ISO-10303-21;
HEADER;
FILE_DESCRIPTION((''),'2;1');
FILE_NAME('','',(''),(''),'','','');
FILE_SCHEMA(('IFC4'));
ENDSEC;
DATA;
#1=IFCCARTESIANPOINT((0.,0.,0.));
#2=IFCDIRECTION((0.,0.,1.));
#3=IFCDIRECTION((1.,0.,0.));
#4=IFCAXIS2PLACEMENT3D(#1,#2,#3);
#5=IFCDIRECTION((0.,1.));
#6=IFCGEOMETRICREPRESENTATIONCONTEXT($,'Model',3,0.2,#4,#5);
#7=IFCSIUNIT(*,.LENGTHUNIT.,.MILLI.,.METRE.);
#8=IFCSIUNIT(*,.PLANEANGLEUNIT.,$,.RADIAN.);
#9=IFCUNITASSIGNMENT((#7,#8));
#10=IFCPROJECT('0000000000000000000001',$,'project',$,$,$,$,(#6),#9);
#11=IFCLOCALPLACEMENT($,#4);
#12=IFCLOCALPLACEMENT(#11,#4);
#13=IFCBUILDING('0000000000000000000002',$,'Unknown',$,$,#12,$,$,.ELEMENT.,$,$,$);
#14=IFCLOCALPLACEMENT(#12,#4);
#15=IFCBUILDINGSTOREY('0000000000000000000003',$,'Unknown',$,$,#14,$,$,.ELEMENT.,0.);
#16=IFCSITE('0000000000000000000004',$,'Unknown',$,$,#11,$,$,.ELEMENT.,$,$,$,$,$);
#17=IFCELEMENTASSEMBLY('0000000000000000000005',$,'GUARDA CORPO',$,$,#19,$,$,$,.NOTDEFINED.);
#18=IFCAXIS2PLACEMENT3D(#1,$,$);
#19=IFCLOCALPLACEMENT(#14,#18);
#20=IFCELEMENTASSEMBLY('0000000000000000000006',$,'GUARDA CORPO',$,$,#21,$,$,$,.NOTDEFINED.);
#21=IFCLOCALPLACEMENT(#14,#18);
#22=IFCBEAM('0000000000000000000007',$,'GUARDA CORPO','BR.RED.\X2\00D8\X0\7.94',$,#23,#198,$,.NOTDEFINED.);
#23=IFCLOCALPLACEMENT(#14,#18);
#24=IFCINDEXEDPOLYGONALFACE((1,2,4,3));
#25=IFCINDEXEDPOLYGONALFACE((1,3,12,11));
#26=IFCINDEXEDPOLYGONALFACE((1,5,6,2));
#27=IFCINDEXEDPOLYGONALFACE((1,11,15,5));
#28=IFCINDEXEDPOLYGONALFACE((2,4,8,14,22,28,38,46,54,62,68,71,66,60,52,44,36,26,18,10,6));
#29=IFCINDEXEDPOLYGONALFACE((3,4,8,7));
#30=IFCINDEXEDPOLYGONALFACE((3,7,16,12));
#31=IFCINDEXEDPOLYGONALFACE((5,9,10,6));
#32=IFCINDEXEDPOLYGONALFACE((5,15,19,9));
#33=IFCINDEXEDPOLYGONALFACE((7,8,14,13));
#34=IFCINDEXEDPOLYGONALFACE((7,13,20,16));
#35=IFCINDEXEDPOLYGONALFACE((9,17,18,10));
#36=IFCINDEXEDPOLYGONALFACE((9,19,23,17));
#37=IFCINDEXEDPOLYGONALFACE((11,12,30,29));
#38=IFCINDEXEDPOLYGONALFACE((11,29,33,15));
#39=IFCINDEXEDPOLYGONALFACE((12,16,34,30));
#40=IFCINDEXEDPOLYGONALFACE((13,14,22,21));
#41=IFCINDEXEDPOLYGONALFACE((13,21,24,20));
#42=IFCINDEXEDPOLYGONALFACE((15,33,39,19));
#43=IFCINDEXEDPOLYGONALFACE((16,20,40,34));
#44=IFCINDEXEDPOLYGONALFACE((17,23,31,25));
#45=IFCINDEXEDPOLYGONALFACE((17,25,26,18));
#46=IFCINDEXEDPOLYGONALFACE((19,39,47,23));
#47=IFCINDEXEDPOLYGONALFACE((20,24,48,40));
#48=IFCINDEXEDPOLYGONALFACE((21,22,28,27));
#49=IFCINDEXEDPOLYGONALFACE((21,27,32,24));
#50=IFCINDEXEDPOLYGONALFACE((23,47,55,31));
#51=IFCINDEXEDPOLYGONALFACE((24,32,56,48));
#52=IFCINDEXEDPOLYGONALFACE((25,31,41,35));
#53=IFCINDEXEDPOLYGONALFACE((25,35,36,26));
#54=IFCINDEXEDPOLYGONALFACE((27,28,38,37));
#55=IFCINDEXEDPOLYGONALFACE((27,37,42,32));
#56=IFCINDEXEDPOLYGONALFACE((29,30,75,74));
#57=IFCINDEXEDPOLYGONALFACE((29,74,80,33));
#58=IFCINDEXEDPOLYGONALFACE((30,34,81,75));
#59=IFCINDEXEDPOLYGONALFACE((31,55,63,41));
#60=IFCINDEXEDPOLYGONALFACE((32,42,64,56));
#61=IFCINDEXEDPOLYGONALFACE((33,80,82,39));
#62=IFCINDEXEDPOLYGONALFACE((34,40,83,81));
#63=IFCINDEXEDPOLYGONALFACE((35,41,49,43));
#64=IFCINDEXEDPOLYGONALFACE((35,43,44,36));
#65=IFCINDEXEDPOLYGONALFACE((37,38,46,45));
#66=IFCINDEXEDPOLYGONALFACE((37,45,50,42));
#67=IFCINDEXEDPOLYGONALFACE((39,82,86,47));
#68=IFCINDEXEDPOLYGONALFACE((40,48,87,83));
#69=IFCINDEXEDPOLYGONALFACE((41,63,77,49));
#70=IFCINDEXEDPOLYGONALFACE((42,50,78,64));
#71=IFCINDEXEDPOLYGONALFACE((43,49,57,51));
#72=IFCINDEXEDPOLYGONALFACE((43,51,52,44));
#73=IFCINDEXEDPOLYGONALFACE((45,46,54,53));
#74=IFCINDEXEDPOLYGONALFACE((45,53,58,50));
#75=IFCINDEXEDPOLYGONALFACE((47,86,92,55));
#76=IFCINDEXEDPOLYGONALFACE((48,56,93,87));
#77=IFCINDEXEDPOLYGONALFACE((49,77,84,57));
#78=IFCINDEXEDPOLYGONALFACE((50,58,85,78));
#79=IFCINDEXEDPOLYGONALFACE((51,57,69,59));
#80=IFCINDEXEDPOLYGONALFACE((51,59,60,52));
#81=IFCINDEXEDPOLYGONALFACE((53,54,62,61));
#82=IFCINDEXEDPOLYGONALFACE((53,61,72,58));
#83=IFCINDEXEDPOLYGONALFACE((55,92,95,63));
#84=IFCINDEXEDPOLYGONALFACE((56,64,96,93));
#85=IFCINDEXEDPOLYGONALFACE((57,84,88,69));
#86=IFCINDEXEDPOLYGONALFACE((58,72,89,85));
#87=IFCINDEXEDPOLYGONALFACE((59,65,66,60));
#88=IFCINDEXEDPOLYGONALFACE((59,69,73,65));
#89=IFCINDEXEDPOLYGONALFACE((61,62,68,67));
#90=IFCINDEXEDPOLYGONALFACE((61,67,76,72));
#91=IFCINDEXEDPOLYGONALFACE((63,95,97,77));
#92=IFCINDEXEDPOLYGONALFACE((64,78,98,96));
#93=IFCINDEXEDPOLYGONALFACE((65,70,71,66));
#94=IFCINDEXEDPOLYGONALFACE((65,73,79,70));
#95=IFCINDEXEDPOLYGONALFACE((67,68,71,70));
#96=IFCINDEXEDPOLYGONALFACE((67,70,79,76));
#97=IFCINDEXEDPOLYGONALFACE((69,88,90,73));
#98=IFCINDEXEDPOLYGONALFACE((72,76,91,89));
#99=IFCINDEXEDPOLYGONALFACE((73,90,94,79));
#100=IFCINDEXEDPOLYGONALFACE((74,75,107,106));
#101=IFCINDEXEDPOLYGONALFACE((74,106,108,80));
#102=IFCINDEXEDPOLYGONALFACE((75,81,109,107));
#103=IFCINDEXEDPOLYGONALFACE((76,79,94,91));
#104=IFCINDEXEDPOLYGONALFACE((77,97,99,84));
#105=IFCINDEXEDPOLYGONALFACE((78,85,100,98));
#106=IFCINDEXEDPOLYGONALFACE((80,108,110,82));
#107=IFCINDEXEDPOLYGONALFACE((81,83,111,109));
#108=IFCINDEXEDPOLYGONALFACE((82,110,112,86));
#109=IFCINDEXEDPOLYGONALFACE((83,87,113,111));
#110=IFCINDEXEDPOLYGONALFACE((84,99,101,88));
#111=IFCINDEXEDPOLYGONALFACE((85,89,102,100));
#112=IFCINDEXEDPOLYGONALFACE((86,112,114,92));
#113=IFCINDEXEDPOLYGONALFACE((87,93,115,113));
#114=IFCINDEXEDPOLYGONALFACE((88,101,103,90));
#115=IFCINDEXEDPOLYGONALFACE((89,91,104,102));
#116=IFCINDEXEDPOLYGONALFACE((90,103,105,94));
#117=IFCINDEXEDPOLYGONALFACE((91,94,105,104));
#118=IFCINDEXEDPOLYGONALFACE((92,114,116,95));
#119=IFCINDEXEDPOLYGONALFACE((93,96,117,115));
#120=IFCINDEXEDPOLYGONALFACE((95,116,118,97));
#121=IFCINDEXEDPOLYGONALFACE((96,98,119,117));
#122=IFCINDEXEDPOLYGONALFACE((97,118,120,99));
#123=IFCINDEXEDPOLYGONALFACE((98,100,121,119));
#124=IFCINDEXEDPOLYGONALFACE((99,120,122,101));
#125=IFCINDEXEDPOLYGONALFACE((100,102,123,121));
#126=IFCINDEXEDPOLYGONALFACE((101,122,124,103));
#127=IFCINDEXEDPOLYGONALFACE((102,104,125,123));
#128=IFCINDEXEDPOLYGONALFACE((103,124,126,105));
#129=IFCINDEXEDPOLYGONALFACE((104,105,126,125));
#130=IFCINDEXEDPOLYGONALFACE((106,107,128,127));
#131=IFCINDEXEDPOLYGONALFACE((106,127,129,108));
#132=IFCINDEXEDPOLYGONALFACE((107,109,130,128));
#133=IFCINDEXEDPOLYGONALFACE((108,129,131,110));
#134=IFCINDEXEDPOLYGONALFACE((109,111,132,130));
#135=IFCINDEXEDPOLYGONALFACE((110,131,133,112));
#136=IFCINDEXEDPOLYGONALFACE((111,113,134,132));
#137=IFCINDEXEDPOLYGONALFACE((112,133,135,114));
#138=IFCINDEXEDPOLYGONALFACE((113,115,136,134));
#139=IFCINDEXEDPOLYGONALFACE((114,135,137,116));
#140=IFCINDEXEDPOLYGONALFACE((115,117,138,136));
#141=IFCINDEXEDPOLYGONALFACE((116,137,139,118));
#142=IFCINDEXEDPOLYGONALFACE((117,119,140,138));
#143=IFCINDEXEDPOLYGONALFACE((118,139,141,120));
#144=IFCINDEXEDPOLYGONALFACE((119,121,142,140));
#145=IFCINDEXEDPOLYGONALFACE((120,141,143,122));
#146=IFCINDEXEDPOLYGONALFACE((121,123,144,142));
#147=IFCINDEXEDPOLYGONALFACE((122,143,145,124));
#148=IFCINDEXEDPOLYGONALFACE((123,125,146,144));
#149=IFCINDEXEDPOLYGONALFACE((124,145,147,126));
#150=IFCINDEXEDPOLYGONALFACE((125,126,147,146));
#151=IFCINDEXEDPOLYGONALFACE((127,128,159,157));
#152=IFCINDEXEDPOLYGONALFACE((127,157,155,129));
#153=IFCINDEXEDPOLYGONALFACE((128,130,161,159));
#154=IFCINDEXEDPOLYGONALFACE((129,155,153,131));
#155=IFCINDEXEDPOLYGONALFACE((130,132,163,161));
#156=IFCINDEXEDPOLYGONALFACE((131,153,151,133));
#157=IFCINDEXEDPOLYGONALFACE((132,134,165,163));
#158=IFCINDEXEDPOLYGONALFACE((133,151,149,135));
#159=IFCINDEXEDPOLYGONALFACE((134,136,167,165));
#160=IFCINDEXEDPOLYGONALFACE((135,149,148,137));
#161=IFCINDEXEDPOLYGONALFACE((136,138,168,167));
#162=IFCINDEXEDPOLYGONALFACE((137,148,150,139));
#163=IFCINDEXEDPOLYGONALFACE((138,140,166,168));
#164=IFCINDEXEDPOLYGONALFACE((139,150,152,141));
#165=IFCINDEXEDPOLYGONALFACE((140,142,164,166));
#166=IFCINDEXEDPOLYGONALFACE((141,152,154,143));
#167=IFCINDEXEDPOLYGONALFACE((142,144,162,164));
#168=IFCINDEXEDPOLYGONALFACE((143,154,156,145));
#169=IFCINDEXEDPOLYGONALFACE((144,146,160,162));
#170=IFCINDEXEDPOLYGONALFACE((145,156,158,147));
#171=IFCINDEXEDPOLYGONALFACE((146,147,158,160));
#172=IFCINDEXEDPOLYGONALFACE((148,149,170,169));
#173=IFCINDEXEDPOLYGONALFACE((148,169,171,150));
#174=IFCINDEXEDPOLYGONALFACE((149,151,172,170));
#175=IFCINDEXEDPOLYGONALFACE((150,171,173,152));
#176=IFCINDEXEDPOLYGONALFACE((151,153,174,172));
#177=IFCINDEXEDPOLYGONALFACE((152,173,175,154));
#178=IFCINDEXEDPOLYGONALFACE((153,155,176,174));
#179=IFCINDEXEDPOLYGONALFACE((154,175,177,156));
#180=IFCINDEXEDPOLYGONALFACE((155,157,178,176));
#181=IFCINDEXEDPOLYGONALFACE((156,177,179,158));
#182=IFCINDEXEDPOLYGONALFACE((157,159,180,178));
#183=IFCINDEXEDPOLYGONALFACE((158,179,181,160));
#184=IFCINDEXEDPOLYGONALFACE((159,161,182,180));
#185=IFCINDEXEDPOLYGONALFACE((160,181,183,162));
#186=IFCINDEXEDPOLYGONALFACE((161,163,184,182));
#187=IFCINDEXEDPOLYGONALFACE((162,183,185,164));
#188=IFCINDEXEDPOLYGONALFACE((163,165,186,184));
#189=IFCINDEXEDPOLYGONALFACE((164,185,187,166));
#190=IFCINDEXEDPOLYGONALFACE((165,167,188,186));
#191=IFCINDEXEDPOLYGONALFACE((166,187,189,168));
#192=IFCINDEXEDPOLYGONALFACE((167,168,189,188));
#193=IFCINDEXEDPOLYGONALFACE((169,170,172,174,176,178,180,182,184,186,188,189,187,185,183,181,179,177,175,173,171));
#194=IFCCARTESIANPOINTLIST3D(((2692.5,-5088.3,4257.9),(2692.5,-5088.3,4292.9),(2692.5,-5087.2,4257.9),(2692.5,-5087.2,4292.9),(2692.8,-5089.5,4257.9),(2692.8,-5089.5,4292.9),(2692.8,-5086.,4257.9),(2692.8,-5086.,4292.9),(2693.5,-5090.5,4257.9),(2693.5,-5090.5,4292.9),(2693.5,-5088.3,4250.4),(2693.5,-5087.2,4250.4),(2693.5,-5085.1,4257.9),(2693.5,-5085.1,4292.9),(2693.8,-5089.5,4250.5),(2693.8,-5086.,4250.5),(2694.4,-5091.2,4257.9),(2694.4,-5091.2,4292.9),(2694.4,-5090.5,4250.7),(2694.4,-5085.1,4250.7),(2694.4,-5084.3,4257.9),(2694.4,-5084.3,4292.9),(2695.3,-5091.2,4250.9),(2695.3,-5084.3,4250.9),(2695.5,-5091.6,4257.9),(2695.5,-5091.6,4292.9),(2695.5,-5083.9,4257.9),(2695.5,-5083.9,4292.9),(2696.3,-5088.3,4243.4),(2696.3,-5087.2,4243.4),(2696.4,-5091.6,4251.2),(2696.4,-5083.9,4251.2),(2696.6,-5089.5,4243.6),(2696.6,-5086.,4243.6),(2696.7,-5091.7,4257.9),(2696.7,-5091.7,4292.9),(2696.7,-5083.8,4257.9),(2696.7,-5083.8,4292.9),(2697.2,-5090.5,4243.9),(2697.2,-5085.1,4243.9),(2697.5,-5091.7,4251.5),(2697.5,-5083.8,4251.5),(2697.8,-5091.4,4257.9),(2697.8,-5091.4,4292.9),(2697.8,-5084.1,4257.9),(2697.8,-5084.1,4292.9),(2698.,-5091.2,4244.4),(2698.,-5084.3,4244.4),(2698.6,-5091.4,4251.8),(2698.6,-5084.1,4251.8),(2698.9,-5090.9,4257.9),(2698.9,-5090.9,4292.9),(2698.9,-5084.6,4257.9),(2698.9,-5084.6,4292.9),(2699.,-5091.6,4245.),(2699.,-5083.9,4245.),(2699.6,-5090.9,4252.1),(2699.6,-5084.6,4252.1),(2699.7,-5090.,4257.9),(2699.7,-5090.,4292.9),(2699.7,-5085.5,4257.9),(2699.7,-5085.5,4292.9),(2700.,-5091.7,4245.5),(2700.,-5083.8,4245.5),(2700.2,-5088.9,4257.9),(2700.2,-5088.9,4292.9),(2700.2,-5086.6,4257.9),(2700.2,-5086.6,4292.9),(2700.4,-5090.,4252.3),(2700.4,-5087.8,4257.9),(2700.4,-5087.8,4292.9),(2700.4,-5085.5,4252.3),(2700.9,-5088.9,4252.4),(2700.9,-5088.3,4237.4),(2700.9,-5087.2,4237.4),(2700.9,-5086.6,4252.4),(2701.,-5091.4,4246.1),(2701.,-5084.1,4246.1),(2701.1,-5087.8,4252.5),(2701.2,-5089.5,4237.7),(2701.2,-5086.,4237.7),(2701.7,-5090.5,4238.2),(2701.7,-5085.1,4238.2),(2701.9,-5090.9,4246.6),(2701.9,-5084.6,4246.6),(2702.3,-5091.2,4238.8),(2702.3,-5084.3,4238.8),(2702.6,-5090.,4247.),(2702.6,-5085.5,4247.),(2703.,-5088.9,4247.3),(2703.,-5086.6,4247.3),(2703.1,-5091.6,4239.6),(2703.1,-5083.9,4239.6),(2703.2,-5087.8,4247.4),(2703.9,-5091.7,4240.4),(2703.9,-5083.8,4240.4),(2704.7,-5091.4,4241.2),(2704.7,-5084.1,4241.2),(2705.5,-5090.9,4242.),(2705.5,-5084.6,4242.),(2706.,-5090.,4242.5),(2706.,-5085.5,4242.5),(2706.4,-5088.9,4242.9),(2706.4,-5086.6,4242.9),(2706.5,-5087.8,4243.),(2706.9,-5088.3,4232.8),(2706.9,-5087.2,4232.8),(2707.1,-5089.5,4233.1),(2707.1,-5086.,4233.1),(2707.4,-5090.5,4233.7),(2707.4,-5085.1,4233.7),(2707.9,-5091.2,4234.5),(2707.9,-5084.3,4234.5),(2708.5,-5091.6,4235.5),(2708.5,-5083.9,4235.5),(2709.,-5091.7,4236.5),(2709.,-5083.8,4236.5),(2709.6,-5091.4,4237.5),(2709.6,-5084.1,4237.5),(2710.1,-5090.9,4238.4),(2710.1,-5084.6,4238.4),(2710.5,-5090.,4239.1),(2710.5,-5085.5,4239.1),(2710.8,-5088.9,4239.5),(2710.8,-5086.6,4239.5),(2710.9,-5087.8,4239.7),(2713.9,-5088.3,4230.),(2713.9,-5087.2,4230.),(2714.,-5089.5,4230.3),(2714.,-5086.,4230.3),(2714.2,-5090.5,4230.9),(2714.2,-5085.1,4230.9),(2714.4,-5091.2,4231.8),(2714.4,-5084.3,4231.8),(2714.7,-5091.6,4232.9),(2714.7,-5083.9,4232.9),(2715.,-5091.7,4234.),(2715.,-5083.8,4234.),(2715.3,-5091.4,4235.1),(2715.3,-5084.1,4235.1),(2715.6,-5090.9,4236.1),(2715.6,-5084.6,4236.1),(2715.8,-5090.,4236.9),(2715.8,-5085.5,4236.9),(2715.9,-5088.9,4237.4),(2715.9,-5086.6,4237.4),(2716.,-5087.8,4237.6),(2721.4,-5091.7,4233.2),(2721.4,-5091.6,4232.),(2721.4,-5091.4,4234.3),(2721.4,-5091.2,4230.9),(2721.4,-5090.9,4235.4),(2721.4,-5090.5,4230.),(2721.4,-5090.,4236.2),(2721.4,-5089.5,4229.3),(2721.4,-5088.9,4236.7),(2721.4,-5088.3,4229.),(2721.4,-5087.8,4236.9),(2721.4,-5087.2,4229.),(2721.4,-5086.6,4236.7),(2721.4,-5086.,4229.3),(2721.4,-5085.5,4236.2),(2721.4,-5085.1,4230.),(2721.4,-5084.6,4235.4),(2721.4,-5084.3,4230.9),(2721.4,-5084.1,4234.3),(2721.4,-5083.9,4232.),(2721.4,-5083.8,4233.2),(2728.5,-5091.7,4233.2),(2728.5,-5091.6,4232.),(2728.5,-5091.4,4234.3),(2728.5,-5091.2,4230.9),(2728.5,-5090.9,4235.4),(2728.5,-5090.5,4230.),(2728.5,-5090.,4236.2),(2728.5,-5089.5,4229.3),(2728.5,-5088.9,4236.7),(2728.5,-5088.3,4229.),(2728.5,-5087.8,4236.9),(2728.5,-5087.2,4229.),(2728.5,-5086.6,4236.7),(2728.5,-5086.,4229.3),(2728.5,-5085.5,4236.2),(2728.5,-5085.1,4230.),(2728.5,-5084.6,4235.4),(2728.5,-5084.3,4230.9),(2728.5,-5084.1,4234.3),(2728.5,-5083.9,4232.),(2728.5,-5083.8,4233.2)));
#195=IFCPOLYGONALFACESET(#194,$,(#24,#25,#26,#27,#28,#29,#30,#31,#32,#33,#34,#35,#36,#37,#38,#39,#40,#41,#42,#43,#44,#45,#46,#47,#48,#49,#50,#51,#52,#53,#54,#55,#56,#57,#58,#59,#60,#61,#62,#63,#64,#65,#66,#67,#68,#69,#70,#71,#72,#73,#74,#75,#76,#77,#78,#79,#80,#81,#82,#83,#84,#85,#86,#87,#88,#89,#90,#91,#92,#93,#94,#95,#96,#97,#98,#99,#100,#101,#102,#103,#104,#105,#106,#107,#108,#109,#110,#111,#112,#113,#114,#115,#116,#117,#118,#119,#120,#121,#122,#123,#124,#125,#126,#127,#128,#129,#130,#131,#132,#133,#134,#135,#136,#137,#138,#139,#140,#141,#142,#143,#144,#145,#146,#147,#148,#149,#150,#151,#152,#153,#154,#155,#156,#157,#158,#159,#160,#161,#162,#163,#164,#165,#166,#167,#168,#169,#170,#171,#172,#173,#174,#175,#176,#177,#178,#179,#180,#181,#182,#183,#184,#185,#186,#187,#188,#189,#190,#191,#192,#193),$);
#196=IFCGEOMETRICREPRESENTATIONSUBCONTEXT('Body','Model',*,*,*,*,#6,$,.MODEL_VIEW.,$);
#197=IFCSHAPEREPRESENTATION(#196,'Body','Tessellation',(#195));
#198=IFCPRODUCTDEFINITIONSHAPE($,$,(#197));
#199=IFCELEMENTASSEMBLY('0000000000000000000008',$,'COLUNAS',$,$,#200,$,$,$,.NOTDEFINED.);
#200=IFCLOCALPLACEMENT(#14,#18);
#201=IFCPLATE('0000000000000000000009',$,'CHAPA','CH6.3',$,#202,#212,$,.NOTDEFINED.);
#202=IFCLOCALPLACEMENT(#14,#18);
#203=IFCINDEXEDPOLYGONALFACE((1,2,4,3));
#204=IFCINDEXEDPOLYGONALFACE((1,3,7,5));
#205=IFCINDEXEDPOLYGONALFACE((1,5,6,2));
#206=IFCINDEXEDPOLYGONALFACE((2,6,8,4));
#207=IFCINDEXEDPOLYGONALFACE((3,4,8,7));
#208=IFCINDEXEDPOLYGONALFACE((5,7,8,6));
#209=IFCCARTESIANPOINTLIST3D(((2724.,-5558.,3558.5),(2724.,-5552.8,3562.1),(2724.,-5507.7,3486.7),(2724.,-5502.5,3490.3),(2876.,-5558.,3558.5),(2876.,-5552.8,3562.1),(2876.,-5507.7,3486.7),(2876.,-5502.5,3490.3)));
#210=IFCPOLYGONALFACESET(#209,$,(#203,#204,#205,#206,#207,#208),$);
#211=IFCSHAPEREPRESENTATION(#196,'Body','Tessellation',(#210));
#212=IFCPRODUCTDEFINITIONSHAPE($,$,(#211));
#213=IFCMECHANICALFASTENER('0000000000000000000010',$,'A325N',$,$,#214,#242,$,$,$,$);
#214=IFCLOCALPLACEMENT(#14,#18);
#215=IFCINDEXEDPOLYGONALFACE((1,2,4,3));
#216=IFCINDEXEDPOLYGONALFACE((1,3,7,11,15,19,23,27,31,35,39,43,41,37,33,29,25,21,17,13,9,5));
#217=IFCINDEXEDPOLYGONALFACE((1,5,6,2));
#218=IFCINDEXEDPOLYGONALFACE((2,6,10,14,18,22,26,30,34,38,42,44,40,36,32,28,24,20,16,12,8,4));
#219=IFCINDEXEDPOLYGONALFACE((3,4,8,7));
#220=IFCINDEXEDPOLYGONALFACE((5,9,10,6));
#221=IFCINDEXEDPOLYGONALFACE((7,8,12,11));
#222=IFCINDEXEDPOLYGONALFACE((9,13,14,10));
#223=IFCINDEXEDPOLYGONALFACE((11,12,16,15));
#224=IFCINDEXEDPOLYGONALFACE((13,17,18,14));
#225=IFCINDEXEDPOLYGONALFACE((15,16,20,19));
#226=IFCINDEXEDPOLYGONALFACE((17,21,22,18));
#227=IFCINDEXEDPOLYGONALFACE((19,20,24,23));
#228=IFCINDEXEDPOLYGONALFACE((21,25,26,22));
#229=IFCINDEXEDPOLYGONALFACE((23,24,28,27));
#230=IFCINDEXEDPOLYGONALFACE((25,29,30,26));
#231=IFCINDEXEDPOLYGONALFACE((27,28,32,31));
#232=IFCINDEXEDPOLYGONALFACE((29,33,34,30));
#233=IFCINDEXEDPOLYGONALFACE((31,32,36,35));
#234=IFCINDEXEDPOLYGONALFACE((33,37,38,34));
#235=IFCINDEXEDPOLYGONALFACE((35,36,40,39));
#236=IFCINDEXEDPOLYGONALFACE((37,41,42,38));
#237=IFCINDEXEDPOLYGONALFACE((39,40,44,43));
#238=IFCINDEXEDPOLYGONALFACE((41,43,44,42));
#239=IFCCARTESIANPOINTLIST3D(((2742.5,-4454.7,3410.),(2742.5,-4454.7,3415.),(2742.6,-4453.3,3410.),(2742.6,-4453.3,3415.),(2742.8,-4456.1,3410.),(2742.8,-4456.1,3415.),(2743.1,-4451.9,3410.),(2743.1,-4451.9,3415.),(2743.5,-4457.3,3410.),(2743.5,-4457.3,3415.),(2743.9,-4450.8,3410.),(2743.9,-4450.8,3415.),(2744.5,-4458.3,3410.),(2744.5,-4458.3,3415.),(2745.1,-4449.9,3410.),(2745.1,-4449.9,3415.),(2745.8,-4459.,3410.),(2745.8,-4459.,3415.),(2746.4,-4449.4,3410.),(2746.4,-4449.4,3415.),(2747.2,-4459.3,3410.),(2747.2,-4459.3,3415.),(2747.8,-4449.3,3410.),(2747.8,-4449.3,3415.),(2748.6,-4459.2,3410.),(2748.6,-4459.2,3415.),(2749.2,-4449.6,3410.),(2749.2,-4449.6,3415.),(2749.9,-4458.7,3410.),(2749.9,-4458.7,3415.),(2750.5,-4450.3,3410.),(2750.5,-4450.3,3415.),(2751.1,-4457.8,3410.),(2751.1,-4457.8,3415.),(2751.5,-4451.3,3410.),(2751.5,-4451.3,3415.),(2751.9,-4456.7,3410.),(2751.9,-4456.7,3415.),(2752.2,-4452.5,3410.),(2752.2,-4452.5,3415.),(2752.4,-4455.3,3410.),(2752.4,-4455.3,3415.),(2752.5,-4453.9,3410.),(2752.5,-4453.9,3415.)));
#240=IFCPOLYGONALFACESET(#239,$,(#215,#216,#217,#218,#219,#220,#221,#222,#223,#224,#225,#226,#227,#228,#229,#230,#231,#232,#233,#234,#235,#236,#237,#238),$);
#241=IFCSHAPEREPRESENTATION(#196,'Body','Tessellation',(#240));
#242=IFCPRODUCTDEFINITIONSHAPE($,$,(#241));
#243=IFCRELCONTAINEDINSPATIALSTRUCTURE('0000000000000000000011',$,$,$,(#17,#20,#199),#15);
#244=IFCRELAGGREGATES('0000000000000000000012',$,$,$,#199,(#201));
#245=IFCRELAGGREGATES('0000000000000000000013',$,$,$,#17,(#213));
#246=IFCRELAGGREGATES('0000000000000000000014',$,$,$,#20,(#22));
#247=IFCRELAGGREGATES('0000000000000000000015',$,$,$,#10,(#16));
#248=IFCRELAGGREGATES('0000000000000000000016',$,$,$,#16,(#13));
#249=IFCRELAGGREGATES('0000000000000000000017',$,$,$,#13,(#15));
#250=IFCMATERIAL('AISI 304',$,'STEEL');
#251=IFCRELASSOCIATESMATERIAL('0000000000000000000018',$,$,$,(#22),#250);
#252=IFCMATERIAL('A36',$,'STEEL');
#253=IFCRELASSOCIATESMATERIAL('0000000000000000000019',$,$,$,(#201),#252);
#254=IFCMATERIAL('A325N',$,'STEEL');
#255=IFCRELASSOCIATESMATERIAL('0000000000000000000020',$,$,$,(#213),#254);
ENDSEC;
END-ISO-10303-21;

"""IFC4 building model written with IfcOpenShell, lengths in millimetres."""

from ifc_helpers import new_model, entity, si_unit, direction, frame, origin_with_axes, place, context, subcontext, project, spatial, line, arc, indexed_curve, outline, extrude, source, transform, mapped, material, element, aggregate, save


model = new_model("IFC4")

# Units and contexts
model_context = context("Model", 3, precision=0.2, world=origin_with_axes(), true_north=direction((0.0, 1.0)))
body_context = subcontext(model_context, "Body", "Model", "MODEL_VIEW")
ifc_project = project(units=[si_unit("LENGTHUNIT", "METRE", prefix="MILLI"), si_unit("PLANEANGLEUNIT", "RADIAN")], contexts=[model_context])

# Site, building, storey
site_placement = place(None, origin_with_axes())
site = spatial("IfcSite", under=ifc_project, at=site_placement, Name="Unknown", CompositionType="ELEMENT")
building_placement = place(site_placement, origin_with_axes())
building = spatial("IfcBuilding", under=site, at=building_placement, Name="Unknown", CompositionType="ELEMENT")
storey_placement = place(building_placement, origin_with_axes())
storey = spatial("IfcBuildingStorey", under=building, at=storey_placement, Name="Unknown", CompositionType="ELEMENT", Elevation=0.0)

# Element assembly
assembly_1_placement = place(storey_placement, frame((2747.5, -4429.7, 3415.0), z_axis=(-0.000512, -1.0, -0.000003), x_axis=(0.000003, -0.000003, 1.0)))
assembly_1 = element("IfcElementAssembly", 1, at=assembly_1_placement, inside=storey, Name="GUARDA CORPO", PredefinedType="NOTDEFINED")
ifc_material_1 = material(Name="AISI 304", Category="STEEL")

# Shared definitions
ifc_material_2 = material(Name="A36", Category="STEEL")

# Element assembly, beam
assembly_2_placement = place(storey_placement, frame((2747.5, -5087.8, 3415.0), z_axis=(-1.0, 0.000512, 0.000003), x_axis=(0.000003, 0.000003, 1.0)))
assembly_2 = element("IfcElementAssembly", 2, at=assembly_2_placement, inside=storey, Name="GUARDA CORPO", PredefinedType="NOTDEFINED")
beam_1_placement = place(assembly_2_placement, frame((877.9, 0.0, 51.2), z_axis=(-0.000003, 0.000513, -1.0), x_axis=(-1.0, 0.0, 0.000003)))
beam_1 = element("IfcBeam", 3, at=beam_1_placement, material=ifc_material_1, Name="GUARDA CORPO", Description="BR.RED.Ø7.94", PredefinedType="NOTDEFINED", context=body_context, shape_type="SolidModel", body=[
    entity("IfcSweptDiskSolid", entity("IfcIndexedPolyCurve", entity("IfcCartesianPointList3D", [[0.0, 0.0, 0.0], [35.0, 0.0, 0.0], [52.7, 0.0, 7.3], [60.0, 0.0, 25.0], [60.0, 0.0, 32.1]]), [entity("IfcLineIndex", [1, 2]), entity("IfcArcIndex", [2, 3, 4]), entity("IfcLineIndex", [4, 5])]), 4.0),
])

# Element assembly, plate
assembly_3_placement = place(storey_placement, frame((2800.0, -5581.0, 3557.7), z_axis=(-1.0, 0.0, 0.0), x_axis=(0.0, 0.0, -1.0)))
assembly_3 = element("IfcElementAssembly", 4, at=assembly_3_placement, inside=storey, Name="COLUNAS", PredefinedType="NOTDEFINED")
plate_1_placement = place(assembly_3_placement, frame((69.2, -75.9, 76.0), z_axis=(-0.573553, -0.819168, 0.0), x_axis=(-0.819168, 0.573553, 0.0)))
plate_1 = element("IfcPlate", 5, at=plate_1_placement, material=ifc_material_2, Name="CHAPA", Description="CH6.3", PredefinedType="NOTDEFINED", context=body_context, shape_type="SolidModel", body=[
    extrude(outline(indexed_curve([(0.0, 0.0), (87.7, 0.0), (87.7, 152.0), (0.0, 152.0)], segments=[line(1, 2, 3, 4, 1)])), frame((0.0, 0.0, 3.1), z_axis=(0.0, 0.0, 1.0), x_axis=(1.0, 0.0, 0.0)), (0.0, 0.0, -1.0), 6.3),
])
aggregate(assembly_3, [plate_1])

# Mechanical fastener
ifc_material_3 = material(Name="A325N", Category="STEEL")
shared_shape_1 = source(origin_with_axes(), body_context, "Body", "SweptSolid", [
    extrude(outline(indexed_curve([(5.0, 0.0), (0.0, 5.0), (-5.0, 0.0), (0.0, -5.0)], segments=[arc(1, 2, 3), arc(3, 4, 1)])), frame((0.0, 0.0, 0.0), z_axis=(0.0, 0.0, -1.0), x_axis=(0.0, 1.0, 0.0)), (0.0, 0.0, 1.0), 5.0),
])
mechanical_fastener_1_placement = place(assembly_1_placement, frame((0.0, 0.0, 24.6), z_axis=(1.0, 0.000004, -0.000001), x_axis=(0.000001, -0.471416, -0.881911)))
mechanical_fastener_1 = element("IfcMechanicalFastener", 6, at=mechanical_fastener_1_placement, material=ifc_material_3, Name="A325N", context=body_context, shape_type="MappedRepresentation", body=[
    mapped(shared_shape_1, transform((0.0, 0.0, 0.0))),
])
aggregate(assembly_1, [mechanical_fastener_1])
aggregate(assembly_2, [beam_1])

save(model, "model.ifc")
